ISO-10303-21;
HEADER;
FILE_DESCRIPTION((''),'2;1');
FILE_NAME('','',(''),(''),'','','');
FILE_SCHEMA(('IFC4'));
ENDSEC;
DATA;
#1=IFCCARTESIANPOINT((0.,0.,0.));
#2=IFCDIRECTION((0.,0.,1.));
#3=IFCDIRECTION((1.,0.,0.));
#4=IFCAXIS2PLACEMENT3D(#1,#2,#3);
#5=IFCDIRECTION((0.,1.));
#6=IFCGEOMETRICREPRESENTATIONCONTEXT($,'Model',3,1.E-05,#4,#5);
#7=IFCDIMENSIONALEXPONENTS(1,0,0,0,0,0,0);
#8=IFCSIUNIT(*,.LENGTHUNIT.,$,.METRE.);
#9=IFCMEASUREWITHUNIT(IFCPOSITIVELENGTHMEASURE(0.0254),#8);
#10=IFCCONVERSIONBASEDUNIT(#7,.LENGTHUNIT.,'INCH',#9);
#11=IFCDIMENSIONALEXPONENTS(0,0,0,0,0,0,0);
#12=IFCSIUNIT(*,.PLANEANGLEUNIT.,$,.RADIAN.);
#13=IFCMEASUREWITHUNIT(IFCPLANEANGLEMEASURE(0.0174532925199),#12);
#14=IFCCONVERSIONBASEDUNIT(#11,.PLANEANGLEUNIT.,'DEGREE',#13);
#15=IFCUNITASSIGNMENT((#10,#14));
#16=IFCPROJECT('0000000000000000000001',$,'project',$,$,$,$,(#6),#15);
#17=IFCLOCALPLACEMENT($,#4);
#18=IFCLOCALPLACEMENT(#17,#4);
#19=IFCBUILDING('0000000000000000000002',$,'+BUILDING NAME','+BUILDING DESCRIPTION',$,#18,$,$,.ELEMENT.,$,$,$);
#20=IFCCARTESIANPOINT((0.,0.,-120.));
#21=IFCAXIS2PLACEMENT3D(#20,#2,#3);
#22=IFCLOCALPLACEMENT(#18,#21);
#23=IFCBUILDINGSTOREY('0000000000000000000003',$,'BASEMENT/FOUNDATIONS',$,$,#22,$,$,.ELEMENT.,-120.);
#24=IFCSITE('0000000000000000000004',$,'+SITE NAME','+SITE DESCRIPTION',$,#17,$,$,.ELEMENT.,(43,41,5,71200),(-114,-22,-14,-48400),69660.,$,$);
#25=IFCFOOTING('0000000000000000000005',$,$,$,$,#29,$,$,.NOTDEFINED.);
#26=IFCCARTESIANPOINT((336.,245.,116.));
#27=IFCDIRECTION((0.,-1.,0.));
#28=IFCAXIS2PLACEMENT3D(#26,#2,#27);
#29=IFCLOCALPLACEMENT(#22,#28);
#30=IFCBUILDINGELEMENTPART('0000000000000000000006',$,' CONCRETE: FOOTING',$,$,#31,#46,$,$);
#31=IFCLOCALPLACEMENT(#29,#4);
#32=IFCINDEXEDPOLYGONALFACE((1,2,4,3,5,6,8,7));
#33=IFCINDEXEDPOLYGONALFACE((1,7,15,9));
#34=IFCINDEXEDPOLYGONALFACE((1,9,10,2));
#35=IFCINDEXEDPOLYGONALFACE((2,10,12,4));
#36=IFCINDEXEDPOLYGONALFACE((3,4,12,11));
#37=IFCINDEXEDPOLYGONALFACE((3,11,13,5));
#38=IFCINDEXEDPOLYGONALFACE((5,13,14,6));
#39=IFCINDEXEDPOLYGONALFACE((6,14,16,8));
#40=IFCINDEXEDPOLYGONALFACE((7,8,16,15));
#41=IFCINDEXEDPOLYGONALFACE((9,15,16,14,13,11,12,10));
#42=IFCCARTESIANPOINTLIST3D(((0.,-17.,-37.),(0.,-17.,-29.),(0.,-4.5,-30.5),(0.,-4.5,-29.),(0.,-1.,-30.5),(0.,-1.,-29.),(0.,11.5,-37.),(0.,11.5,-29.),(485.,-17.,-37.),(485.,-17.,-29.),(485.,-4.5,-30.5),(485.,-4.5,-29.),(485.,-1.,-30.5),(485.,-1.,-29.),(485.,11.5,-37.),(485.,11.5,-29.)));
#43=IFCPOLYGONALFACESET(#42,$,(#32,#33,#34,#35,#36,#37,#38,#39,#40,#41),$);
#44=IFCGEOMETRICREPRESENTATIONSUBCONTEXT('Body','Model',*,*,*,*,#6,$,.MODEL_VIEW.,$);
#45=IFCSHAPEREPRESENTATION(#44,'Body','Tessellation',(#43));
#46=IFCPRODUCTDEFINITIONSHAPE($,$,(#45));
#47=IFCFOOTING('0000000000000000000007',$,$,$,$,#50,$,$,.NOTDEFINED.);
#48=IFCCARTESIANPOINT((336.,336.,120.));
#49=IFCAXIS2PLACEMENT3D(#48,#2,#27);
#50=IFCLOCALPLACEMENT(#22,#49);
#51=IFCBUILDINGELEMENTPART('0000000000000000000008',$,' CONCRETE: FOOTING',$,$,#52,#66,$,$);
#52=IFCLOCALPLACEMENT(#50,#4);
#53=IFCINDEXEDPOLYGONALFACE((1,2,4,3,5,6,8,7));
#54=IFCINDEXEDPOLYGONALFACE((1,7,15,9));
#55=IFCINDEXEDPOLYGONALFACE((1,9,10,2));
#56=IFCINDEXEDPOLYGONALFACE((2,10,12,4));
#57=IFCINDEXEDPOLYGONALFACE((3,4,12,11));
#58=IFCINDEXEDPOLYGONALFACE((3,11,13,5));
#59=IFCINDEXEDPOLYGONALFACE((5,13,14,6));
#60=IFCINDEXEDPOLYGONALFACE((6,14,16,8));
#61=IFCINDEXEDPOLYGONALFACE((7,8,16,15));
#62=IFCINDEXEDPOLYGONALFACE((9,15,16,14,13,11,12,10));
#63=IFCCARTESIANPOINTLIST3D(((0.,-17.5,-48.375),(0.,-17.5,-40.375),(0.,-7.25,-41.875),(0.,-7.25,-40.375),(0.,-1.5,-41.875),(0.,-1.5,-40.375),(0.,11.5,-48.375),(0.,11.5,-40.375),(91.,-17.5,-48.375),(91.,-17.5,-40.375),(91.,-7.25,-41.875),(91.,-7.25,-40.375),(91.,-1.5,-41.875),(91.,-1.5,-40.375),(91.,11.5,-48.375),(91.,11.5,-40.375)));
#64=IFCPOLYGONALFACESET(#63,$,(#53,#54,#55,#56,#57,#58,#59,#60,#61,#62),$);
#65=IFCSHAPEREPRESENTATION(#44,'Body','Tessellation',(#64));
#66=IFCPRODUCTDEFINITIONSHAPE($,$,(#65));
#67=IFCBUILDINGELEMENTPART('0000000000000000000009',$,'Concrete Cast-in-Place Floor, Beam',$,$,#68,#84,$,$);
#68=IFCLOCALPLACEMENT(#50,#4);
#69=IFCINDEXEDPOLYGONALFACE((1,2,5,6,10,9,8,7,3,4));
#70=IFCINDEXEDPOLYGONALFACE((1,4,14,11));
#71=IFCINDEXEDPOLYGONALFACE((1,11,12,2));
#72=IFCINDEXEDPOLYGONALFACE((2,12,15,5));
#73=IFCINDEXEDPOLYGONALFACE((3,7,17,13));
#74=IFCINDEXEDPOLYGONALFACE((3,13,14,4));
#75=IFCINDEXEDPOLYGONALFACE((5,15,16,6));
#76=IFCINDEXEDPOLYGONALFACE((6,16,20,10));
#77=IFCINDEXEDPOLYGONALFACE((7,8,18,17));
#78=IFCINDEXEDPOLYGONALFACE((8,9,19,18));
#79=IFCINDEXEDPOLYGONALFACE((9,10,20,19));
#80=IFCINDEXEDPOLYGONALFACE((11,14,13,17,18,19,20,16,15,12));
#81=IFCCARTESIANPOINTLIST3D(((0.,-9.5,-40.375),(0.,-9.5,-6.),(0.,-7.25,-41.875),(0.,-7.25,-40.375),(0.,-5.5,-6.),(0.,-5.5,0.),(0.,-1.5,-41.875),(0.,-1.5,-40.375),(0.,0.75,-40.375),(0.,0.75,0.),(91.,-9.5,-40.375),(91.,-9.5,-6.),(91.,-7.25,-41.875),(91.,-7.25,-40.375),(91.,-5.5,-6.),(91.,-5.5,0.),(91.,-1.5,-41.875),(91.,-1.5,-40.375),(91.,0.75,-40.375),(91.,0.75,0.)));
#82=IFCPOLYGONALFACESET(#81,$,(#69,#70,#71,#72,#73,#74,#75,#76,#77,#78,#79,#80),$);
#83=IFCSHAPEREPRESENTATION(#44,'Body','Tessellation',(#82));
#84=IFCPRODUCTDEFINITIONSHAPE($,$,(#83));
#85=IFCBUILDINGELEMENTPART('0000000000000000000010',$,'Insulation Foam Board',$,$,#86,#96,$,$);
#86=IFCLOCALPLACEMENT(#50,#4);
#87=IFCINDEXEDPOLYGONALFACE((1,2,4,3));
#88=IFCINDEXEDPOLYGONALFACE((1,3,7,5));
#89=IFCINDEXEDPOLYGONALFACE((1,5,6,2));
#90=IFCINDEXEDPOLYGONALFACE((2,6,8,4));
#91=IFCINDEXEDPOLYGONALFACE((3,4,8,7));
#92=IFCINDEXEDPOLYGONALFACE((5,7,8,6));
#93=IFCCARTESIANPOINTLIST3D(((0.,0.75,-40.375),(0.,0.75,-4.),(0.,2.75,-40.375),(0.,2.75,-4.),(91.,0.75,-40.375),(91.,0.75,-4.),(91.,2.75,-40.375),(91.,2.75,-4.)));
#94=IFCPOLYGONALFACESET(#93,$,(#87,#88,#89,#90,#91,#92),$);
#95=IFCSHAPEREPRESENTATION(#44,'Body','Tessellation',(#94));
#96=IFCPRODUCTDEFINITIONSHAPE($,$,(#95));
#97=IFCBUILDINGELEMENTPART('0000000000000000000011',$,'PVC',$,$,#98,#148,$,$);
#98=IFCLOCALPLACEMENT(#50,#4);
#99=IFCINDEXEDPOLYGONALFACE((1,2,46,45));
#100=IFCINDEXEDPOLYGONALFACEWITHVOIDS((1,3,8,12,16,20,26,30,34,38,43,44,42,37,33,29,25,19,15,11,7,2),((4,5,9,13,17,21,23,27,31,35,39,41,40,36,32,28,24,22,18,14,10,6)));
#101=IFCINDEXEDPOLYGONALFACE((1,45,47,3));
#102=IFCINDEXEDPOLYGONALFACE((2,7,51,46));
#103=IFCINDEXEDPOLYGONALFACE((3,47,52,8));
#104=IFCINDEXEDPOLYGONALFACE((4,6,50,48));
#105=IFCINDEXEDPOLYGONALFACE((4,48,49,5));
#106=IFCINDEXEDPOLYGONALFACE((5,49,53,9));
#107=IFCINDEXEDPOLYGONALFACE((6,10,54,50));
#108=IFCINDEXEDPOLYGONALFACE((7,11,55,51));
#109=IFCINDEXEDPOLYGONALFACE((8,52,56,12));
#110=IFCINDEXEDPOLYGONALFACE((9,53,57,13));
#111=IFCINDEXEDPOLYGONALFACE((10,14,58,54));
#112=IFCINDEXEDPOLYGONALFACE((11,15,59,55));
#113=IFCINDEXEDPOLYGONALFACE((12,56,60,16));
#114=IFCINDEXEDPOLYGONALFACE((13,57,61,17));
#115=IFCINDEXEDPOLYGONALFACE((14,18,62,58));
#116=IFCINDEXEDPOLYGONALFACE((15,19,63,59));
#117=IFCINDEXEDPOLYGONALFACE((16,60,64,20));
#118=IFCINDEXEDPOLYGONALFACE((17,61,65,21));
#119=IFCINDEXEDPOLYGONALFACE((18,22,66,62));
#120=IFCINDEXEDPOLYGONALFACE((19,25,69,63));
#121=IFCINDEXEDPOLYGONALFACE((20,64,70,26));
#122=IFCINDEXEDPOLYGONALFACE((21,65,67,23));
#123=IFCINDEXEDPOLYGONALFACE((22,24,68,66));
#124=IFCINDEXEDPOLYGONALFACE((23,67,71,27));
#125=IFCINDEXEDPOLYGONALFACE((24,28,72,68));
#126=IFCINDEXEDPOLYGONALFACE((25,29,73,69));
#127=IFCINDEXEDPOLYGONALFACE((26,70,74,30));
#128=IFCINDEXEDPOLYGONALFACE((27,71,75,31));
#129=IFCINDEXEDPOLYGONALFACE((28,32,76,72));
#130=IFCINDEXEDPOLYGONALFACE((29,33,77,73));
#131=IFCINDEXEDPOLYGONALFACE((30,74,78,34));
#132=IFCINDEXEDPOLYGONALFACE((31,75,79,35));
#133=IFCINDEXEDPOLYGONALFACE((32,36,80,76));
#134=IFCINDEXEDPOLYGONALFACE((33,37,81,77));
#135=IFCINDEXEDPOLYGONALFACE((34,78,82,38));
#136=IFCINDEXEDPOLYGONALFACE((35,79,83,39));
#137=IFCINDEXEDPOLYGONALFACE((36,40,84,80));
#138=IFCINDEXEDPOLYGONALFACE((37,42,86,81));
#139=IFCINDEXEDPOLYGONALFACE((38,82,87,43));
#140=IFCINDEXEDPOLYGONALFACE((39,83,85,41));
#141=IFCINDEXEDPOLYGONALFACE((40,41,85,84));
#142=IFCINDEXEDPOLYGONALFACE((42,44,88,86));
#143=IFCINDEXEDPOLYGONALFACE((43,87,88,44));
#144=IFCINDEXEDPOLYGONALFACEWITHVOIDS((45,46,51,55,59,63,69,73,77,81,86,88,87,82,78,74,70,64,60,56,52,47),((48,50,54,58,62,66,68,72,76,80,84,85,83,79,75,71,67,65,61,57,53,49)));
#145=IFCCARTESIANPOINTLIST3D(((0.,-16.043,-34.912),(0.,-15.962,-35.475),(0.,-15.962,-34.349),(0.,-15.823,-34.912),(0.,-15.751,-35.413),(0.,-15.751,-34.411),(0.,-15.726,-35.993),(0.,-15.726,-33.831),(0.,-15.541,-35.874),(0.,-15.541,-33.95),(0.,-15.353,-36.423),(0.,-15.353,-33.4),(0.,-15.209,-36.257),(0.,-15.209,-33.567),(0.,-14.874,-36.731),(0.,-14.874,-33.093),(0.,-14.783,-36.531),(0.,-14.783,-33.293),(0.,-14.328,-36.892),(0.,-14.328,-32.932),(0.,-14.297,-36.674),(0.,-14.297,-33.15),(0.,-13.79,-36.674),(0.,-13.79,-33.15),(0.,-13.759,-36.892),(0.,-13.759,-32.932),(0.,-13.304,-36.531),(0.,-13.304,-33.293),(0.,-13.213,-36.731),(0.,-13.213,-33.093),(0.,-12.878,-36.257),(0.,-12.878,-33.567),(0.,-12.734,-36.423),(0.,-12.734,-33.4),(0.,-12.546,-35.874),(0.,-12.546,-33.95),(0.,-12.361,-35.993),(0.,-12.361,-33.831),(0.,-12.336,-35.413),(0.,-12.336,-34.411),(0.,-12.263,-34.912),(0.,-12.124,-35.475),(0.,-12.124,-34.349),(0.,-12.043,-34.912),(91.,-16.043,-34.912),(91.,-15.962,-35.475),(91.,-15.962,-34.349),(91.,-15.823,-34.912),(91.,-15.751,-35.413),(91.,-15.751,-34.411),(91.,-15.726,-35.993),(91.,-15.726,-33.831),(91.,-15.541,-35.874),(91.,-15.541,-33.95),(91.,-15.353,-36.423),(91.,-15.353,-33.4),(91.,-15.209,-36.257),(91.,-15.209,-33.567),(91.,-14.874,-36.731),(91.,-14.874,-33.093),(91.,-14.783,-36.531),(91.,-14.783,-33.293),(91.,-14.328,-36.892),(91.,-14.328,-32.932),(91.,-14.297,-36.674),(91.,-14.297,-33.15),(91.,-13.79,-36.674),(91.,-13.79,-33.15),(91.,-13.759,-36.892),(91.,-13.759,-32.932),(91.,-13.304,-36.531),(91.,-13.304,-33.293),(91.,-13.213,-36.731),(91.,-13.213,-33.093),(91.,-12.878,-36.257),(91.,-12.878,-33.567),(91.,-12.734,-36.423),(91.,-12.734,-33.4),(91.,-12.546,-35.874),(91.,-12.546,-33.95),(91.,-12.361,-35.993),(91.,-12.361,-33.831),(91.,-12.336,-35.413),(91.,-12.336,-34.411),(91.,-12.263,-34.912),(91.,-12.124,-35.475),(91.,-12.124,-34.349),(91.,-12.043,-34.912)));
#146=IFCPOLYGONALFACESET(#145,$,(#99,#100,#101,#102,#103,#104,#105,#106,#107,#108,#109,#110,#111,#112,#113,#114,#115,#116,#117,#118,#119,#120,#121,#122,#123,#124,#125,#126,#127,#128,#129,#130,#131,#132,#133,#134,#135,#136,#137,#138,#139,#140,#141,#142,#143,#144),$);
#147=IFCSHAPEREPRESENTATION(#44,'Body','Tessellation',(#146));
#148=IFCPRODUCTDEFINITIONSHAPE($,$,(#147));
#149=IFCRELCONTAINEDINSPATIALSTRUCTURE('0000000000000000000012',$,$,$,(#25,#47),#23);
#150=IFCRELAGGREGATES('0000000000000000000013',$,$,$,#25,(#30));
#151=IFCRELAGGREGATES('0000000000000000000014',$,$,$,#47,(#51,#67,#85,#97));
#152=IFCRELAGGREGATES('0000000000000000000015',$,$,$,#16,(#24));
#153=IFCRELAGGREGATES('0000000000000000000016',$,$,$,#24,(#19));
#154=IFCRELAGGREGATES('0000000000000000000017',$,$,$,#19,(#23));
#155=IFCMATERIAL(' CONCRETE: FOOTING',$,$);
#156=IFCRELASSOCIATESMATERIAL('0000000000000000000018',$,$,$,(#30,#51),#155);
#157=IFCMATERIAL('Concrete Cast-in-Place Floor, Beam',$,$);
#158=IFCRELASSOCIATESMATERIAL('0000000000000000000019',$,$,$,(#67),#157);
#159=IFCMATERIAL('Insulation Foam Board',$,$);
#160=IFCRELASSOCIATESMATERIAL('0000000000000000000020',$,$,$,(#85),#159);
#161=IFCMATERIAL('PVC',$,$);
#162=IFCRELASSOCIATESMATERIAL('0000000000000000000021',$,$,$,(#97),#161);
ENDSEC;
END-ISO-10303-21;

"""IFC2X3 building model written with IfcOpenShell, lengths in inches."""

from ifc_helpers import new_model, entity, si_unit, converted_unit, point, direction, frame, frame_2d, origin_with_axes, place, context, subcontext, project, spatial, polyline, circle_curve, parameter, trimmed, segment, composite_curve, outline, extrude, material, element, aggregate, save


model = new_model("IFC2X3")

# Units and contexts
model_context = context("Model", 3, precision=1e-05, world=origin_with_axes(), true_north=direction((0.0, 1.0)))
body_context = subcontext(model_context, "Body", "Model", "MODEL_VIEW")
ifc_project = project(units=[converted_unit("LENGTHUNIT", "INCH", entity("IfcPositiveLengthMeasure", 0.0254), si_unit("LENGTHUNIT", "METRE"), dimensions=[1, 0, 0, 0, 0, 0, 0]), converted_unit("PLANEANGLEUNIT", "DEGREE", entity("IfcPlaneAngleMeasure", 0.0174532925199), si_unit("PLANEANGLEUNIT", "RADIAN"), dimensions=[0, 0, 0, 0, 0, 0, 0])], contexts=[model_context])

# Site, building, storey
site_placement = place(None, origin_with_axes())
site = spatial("IfcSite", under=ifc_project, at=site_placement, Name="+SITE NAME", Description="+SITE DESCRIPTION", CompositionType="ELEMENT", RefLatitude=(43, 41, 5, 71200), RefLongitude=(-114, -22, -14, -48400), RefElevation=69660.0)
building_placement = place(site_placement, origin_with_axes())
building = spatial("IfcBuilding", under=site, at=building_placement, Name="+BUILDING NAME", Description="+BUILDING DESCRIPTION", CompositionType="ELEMENT")
storey_placement = place(building_placement, frame((0.0, 0.0, -120.0), z_axis=(0.0, 0.0, 1.0), x_axis=(1.0, 0.0, 0.0)))
storey = spatial("IfcBuildingStorey", under=building, at=storey_placement, Name="BASEMENT/FOUNDATIONS", CompositionType="ELEMENT", Elevation=-120.0)

# Footings, building element parts
ifc_material_1 = material(Name=" CONCRETE: FOOTING")
ifc_material_2 = material(Name="Concrete Cast-in-Place Floor, Beam")
ifc_material_3 = material(Name="Insulation Foam Board")
ifc_material_4 = material(Name="PVC")
footing_1_placement = place(storey_placement, frame((336.0, 245.0, 116.0), z_axis=(0.0, 0.0, 1.0), x_axis=(0.0, -1.0, 0.0)))
footing_1 = element("IfcFooting", 1, at=footing_1_placement, inside=storey, PredefinedType="NOTDEFINED")
building_element_part_1_placement = place(footing_1_placement, origin_with_axes())
building_element_part_1 = element("IfcBuildingElementPart", 2, at=building_element_part_1_placement, material=ifc_material_1, Name=" CONCRETE: FOOTING", context=body_context, shape_type="SweptSolid", body=[
    extrude(outline(polyline([(-14.25, -37.0), (14.25, -37.0), (14.25, -29.0), (1.75, -29.0), (1.75, -30.5), (-1.75, -30.5), (-1.75, -29.0), (-14.25, -29.0), (-14.25, -37.0)])), frame((0.0, -2.75, 0.0), z_axis=(-1.0, 0.0, 0.0), x_axis=(0.0, -1.0, 0.0)), (0.0, 0.0, -1.0), 485.0),
])
aggregate(footing_1, [building_element_part_1])
footing_2_placement = place(storey_placement, frame((336.0, 336.0, 120.0), z_axis=(0.0, 0.0, 1.0), x_axis=(0.0, -1.0, 0.0)))
footing_2 = element("IfcFooting", 3, at=footing_2_placement, inside=storey, PredefinedType="NOTDEFINED")
building_element_part_2_placement = place(footing_2_placement, origin_with_axes())
building_element_part_2 = element("IfcBuildingElementPart", 4, at=building_element_part_2_placement, material=ifc_material_1, Name=" CONCRETE: FOOTING", context=body_context, shape_type="SweptSolid", body=[
    extrude(outline(polyline([(-11.5, -48.375), (17.5, -48.375), (17.5, -40.375), (7.25, -40.375), (7.25, -41.875), (1.5, -41.875), (1.5, -40.375), (-11.5, -40.375), (-11.5, -48.375)])), frame((0.0, 0.0, 0.0), z_axis=(-1.0, 0.0, 0.0), x_axis=(0.0, -1.0, 0.0)), (0.0, 0.0, -1.0), 91.0),
])
building_element_part_3_placement = place(footing_2_placement, origin_with_axes())
building_element_part_3 = element("IfcBuildingElementPart", 5, at=building_element_part_3_placement, material=ifc_material_2, Name="Concrete Cast-in-Place Floor, Beam", context=body_context, shape_type="SweptSolid", body=[
    extrude(outline(polyline([(-0.75, 0.0), (-0.75, -40.375), (1.5, -40.375), (1.5, -41.875), (7.25, -41.875), (7.25, -40.375), (9.5, -40.375), (9.5, -6.0), (5.5, -6.0), (5.5, 0.0), (-0.75, 0.0)])), frame((0.0, 0.0, 0.0), z_axis=(-1.0, 0.0, 0.0), x_axis=(0.0, -1.0, 0.0)), (0.0, 0.0, -1.0), 91.0),
])
building_element_part_4_placement = place(footing_2_placement, origin_with_axes())
building_element_part_4 = element("IfcBuildingElementPart", 6, at=building_element_part_4_placement, material=ifc_material_3, Name="Insulation Foam Board", context=body_context, shape_type="SweptSolid", body=[
    extrude(outline(polyline([(-0.75, -4.0), (-2.75, -4.0), (-2.75, -40.375), (-0.75, -40.375), (-0.75, -4.0)])), frame((0.0, 0.0, 0.0), z_axis=(-1.0, 0.0, 0.0), x_axis=(0.0, -1.0, 0.0)), (0.0, 0.0, -1.0), 91.0),
])
building_element_part_5_placement = place(footing_2_placement, origin_with_axes())
building_element_part_5 = element("IfcBuildingElementPart", 7, at=building_element_part_5_placement, material=ifc_material_4, Name="PVC", context=body_context, shape_type="SweptSolid", body=[
    extrude(outline(composite_curve([segment(trimmed(circle_curve(frame_2d((14.043, -34.912), x_axis=(1.0, 0.0)), 2.0), [point((16.043, -34.912)), parameter(0.0)], [point((12.043, -34.912)), parameter(180.0)], True, "CARTESIAN"), True, "CONTINUOUS"), segment(trimmed(circle_curve(frame_2d((14.043, -34.912), x_axis=(-1.0, 0.0)), 2.0), [point((12.043, -34.912)), parameter(0.0)], [point((16.043, -34.912)), parameter(180.0)], True, "CARTESIAN"), True, "CONTINUOUS")], self_intersect=False), holes=[composite_curve([segment(trimmed(circle_curve(frame_2d((14.043, -34.912), x_axis=(-1.0, 0.0)), 1.78), [point((15.823, -34.912)), parameter(180.0)], [point((12.263, -34.912)), parameter(0.0)], False, "CARTESIAN"), True, "CONTINUOUS"), segment(trimmed(circle_curve(frame_2d((14.043, -34.912), x_axis=(1.0, 0.0)), 1.78), [point((12.263, -34.912)), parameter(180.0)], [point((15.823, -34.912)), parameter(0.0)], False, "CARTESIAN"), True, "CONTINUOUS")], self_intersect=False)]), frame((0.0, 0.0, 0.0), z_axis=(-1.0, 0.0, 0.0), x_axis=(0.0, -1.0, 0.0)), (0.0, 0.0, -1.0), 91.0),
])
aggregate(footing_2, [building_element_part_2, building_element_part_3, building_element_part_4, building_element_part_5])

save(model, "model.ifc")
